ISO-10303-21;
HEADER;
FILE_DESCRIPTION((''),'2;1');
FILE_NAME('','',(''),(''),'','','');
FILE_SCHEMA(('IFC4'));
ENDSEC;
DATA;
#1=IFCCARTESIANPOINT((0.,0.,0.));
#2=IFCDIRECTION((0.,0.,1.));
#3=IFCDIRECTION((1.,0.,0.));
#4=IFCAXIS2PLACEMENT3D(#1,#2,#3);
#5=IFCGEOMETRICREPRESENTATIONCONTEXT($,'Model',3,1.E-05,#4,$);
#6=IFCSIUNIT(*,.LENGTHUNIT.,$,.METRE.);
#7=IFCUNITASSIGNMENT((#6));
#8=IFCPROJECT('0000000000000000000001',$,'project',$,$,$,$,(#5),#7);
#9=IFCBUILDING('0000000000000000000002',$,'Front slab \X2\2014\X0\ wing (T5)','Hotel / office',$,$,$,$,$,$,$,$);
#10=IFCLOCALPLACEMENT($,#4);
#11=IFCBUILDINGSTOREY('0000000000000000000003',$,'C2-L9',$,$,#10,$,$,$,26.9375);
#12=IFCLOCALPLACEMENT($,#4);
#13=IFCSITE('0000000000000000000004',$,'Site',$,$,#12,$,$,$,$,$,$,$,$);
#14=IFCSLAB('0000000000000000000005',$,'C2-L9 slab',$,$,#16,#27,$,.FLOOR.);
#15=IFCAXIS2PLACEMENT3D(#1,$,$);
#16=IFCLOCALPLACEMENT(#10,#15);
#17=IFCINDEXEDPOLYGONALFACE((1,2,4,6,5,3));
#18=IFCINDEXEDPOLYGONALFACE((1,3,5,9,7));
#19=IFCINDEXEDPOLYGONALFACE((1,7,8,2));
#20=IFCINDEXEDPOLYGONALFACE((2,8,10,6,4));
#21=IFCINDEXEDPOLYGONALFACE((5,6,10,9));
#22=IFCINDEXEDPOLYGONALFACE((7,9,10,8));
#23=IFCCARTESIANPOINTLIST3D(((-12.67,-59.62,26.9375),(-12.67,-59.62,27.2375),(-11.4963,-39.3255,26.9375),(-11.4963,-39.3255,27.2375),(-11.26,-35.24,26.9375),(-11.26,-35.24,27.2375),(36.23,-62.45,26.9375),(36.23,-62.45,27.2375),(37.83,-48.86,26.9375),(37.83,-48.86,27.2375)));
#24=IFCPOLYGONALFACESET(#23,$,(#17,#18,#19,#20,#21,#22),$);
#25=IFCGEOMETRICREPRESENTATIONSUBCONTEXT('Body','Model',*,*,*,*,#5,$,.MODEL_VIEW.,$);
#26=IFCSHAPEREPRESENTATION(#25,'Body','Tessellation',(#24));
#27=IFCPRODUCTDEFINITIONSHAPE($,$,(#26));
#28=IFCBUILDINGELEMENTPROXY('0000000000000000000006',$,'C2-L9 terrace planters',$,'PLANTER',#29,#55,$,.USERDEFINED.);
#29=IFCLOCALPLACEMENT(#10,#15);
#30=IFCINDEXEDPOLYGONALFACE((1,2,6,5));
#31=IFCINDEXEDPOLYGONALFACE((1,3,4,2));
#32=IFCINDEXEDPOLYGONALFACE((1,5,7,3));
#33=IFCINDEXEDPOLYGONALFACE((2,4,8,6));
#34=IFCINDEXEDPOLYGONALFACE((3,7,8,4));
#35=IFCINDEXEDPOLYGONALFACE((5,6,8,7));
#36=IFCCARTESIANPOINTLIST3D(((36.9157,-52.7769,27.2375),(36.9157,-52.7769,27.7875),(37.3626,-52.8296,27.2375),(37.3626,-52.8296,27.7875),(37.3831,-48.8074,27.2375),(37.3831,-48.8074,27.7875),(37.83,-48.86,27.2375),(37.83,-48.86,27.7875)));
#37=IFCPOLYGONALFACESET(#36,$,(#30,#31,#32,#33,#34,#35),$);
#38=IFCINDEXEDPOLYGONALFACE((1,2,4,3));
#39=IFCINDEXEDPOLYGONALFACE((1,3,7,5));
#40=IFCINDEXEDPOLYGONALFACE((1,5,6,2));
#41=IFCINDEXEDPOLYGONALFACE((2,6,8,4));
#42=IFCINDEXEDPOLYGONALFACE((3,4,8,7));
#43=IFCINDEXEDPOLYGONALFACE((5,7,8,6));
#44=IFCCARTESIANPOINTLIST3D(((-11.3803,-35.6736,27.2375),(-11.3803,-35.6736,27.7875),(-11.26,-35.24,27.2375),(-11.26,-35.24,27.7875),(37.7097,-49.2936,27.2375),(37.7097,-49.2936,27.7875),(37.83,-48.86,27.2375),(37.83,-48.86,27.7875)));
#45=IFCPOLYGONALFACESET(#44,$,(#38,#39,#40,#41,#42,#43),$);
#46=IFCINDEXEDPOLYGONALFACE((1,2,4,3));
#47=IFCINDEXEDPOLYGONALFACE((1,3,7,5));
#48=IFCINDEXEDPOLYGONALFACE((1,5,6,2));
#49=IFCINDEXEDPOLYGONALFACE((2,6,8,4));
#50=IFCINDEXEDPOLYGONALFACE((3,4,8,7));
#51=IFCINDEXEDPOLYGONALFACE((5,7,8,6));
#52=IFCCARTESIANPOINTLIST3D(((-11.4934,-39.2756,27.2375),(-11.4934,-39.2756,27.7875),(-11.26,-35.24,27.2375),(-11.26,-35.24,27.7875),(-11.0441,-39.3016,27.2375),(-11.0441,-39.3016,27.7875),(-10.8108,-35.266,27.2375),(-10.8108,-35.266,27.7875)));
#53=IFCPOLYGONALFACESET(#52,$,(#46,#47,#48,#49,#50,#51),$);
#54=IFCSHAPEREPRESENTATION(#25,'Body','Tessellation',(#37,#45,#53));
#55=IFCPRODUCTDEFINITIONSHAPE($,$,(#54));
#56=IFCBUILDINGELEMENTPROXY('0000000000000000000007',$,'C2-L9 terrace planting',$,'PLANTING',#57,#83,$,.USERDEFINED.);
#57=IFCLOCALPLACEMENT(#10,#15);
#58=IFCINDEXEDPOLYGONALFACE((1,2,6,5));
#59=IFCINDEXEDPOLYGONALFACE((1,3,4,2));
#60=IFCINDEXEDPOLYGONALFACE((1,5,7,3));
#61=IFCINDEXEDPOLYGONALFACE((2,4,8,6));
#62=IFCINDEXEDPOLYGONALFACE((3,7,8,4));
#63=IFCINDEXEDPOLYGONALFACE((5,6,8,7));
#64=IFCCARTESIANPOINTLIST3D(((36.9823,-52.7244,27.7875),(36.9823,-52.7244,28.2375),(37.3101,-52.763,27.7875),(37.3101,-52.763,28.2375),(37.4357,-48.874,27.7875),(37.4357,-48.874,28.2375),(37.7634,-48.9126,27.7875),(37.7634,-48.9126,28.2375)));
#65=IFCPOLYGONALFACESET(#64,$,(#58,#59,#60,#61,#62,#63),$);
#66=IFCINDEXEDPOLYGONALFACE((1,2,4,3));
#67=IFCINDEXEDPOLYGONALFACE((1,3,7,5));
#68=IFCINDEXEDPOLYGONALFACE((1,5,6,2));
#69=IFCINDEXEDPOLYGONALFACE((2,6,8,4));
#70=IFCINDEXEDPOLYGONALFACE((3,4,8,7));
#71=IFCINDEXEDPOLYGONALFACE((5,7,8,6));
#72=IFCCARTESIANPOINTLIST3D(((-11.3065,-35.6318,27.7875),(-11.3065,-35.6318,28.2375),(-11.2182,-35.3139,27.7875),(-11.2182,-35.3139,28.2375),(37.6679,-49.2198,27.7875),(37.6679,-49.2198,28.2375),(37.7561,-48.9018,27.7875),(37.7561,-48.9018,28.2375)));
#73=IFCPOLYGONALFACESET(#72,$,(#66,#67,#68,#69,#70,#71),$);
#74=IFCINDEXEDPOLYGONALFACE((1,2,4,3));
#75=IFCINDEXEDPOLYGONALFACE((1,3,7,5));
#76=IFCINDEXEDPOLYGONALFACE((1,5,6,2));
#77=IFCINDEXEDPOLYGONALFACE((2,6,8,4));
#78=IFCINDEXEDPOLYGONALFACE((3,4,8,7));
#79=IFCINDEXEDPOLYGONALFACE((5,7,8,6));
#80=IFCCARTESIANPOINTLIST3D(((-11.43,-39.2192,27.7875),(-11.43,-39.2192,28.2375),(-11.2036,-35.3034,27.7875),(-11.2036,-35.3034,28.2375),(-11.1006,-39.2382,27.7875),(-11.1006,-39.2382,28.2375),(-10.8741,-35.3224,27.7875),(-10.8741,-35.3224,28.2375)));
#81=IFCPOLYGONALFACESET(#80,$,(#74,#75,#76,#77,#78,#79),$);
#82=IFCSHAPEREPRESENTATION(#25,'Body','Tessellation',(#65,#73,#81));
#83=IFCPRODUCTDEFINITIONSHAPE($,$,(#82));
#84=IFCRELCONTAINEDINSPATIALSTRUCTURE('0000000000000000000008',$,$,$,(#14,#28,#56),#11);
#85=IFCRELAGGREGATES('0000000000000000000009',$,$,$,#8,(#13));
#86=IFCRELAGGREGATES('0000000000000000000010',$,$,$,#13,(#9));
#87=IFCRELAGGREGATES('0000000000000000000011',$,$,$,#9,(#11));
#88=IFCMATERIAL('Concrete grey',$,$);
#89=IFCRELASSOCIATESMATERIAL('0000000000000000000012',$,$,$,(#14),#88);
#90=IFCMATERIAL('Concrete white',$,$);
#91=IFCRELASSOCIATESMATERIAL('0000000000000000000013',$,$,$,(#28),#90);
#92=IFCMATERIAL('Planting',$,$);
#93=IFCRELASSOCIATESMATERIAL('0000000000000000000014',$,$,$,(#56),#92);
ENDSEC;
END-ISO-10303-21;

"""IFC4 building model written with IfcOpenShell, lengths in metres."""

from ifc_helpers import new_model, si_unit, frame, origin_with_axes, place, context, subcontext, project, spatial, polyline, outline, extrude, material, element, save


model = new_model("IFC4")

# Units and contexts
model_context = context("Model", 3, precision=1e-05, world=origin_with_axes())
body_context = subcontext(model_context, "Body", "Model", "MODEL_VIEW")
ifc_project = project(units=[si_unit("LENGTHUNIT", "METRE")], contexts=[model_context])

# Site, building, storey
site_placement = place(None, origin_with_axes())
site = spatial("IfcSite", under=ifc_project, at=site_placement, Name="Site")
building = spatial("IfcBuilding", under=site, Name="Front slab — wing (T5)", Description="Hotel / office")
storey_placement = place(None, origin_with_axes())
storey = spatial("IfcBuildingStorey", under=building, at=storey_placement, Name="C2-L9", Elevation=26.9375)

# Slab
ifc_material_1 = material(Name="Concrete grey")
slab_placement = place(storey_placement, origin_with_axes())
element("IfcSlab", 1, at=slab_placement, inside=storey, material=ifc_material_1, Name="C2-L9 slab", PredefinedType="FLOOR", context=body_context, shape_type="SweptSolid", body=[
    extrude(outline(polyline([(-11.4963, -39.3255), (-12.67, -59.62), (36.23, -62.45), (37.83, -48.86), (-11.26, -35.24), (-11.4963, -39.3255), (-11.4963, -39.3255)])), frame((0.0, 0.0, 26.9375), z_axis=(0.0, 0.0, 1.0), x_axis=(1.0, 0.0, 0.0)), (0.0, 0.0, 1.0), 0.3),
])

# Building element proxies
ifc_material_2 = material(Name="Concrete white")
proxy_1_placement = place(storey_placement, origin_with_axes())
element("IfcBuildingElementProxy", 2, at=proxy_1_placement, inside=storey, material=ifc_material_2, Name="C2-L9 terrace planters", ObjectType="PLANTER", PredefinedType="USERDEFINED", context=body_context, shape_type="SweptSolid", body=[
    extrude(outline(polyline([(37.3626, -52.8296), (37.83, -48.86), (37.3831, -48.8074), (36.9157, -52.7769), (37.3626, -52.8296)])), frame((0.0, 0.0, 27.2375), z_axis=(0.0, 0.0, 1.0), x_axis=(1.0, 0.0, 0.0)), (0.0, 0.0, 1.0), 0.55),
    extrude(outline(polyline([(37.83, -48.86), (-11.26, -35.24), (-11.3803, -35.6736), (37.7097, -49.2936), (37.83, -48.86)])), frame((0.0, 0.0, 27.2375), z_axis=(0.0, 0.0, 1.0), x_axis=(1.0, 0.0, 0.0)), (0.0, 0.0, 1.0), 0.55),
    extrude(outline(polyline([(-11.26, -35.24), (-11.4934, -39.2756), (-11.0441, -39.3016), (-10.8108, -35.266), (-11.26, -35.24)])), frame((0.0, 0.0, 27.2375), z_axis=(0.0, 0.0, 1.0), x_axis=(1.0, 0.0, 0.0)), (0.0, 0.0, 1.0), 0.55),
])
ifc_material_3 = material(Name="Planting")
proxy_2_placement = place(storey_placement, origin_with_axes())
element("IfcBuildingElementProxy", 3, at=proxy_2_placement, inside=storey, material=ifc_material_3, Name="C2-L9 terrace planting", ObjectType="PLANTING", PredefinedType="USERDEFINED", context=body_context, shape_type="SweptSolid", body=[
    extrude(outline(polyline([(37.3101, -52.763), (37.7634, -48.9126), (37.4357, -48.874), (36.9823, -52.7244), (37.3101, -52.763)])), frame((0.0, 0.0, 27.7875), z_axis=(0.0, 0.0, 1.0), x_axis=(1.0, 0.0, 0.0)), (0.0, 0.0, 1.0), 0.45),
    extrude(outline(polyline([(37.7561, -48.9018), (-11.2182, -35.3139), (-11.3065, -35.6318), (37.6679, -49.2198), (37.7561, -48.9018)])), frame((0.0, 0.0, 27.7875), z_axis=(0.0, 0.0, 1.0), x_axis=(1.0, 0.0, 0.0)), (0.0, 0.0, 1.0), 0.45),
    extrude(outline(polyline([(-11.2036, -35.3034), (-11.43, -39.2192), (-11.1006, -39.2382), (-10.8741, -35.3224), (-11.2036, -35.3034)])), frame((0.0, 0.0, 27.7875), z_axis=(0.0, 0.0, 1.0), x_axis=(1.0, 0.0, 0.0)), (0.0, 0.0, 1.0), 0.45),
])

save(model, "model.ifc")
